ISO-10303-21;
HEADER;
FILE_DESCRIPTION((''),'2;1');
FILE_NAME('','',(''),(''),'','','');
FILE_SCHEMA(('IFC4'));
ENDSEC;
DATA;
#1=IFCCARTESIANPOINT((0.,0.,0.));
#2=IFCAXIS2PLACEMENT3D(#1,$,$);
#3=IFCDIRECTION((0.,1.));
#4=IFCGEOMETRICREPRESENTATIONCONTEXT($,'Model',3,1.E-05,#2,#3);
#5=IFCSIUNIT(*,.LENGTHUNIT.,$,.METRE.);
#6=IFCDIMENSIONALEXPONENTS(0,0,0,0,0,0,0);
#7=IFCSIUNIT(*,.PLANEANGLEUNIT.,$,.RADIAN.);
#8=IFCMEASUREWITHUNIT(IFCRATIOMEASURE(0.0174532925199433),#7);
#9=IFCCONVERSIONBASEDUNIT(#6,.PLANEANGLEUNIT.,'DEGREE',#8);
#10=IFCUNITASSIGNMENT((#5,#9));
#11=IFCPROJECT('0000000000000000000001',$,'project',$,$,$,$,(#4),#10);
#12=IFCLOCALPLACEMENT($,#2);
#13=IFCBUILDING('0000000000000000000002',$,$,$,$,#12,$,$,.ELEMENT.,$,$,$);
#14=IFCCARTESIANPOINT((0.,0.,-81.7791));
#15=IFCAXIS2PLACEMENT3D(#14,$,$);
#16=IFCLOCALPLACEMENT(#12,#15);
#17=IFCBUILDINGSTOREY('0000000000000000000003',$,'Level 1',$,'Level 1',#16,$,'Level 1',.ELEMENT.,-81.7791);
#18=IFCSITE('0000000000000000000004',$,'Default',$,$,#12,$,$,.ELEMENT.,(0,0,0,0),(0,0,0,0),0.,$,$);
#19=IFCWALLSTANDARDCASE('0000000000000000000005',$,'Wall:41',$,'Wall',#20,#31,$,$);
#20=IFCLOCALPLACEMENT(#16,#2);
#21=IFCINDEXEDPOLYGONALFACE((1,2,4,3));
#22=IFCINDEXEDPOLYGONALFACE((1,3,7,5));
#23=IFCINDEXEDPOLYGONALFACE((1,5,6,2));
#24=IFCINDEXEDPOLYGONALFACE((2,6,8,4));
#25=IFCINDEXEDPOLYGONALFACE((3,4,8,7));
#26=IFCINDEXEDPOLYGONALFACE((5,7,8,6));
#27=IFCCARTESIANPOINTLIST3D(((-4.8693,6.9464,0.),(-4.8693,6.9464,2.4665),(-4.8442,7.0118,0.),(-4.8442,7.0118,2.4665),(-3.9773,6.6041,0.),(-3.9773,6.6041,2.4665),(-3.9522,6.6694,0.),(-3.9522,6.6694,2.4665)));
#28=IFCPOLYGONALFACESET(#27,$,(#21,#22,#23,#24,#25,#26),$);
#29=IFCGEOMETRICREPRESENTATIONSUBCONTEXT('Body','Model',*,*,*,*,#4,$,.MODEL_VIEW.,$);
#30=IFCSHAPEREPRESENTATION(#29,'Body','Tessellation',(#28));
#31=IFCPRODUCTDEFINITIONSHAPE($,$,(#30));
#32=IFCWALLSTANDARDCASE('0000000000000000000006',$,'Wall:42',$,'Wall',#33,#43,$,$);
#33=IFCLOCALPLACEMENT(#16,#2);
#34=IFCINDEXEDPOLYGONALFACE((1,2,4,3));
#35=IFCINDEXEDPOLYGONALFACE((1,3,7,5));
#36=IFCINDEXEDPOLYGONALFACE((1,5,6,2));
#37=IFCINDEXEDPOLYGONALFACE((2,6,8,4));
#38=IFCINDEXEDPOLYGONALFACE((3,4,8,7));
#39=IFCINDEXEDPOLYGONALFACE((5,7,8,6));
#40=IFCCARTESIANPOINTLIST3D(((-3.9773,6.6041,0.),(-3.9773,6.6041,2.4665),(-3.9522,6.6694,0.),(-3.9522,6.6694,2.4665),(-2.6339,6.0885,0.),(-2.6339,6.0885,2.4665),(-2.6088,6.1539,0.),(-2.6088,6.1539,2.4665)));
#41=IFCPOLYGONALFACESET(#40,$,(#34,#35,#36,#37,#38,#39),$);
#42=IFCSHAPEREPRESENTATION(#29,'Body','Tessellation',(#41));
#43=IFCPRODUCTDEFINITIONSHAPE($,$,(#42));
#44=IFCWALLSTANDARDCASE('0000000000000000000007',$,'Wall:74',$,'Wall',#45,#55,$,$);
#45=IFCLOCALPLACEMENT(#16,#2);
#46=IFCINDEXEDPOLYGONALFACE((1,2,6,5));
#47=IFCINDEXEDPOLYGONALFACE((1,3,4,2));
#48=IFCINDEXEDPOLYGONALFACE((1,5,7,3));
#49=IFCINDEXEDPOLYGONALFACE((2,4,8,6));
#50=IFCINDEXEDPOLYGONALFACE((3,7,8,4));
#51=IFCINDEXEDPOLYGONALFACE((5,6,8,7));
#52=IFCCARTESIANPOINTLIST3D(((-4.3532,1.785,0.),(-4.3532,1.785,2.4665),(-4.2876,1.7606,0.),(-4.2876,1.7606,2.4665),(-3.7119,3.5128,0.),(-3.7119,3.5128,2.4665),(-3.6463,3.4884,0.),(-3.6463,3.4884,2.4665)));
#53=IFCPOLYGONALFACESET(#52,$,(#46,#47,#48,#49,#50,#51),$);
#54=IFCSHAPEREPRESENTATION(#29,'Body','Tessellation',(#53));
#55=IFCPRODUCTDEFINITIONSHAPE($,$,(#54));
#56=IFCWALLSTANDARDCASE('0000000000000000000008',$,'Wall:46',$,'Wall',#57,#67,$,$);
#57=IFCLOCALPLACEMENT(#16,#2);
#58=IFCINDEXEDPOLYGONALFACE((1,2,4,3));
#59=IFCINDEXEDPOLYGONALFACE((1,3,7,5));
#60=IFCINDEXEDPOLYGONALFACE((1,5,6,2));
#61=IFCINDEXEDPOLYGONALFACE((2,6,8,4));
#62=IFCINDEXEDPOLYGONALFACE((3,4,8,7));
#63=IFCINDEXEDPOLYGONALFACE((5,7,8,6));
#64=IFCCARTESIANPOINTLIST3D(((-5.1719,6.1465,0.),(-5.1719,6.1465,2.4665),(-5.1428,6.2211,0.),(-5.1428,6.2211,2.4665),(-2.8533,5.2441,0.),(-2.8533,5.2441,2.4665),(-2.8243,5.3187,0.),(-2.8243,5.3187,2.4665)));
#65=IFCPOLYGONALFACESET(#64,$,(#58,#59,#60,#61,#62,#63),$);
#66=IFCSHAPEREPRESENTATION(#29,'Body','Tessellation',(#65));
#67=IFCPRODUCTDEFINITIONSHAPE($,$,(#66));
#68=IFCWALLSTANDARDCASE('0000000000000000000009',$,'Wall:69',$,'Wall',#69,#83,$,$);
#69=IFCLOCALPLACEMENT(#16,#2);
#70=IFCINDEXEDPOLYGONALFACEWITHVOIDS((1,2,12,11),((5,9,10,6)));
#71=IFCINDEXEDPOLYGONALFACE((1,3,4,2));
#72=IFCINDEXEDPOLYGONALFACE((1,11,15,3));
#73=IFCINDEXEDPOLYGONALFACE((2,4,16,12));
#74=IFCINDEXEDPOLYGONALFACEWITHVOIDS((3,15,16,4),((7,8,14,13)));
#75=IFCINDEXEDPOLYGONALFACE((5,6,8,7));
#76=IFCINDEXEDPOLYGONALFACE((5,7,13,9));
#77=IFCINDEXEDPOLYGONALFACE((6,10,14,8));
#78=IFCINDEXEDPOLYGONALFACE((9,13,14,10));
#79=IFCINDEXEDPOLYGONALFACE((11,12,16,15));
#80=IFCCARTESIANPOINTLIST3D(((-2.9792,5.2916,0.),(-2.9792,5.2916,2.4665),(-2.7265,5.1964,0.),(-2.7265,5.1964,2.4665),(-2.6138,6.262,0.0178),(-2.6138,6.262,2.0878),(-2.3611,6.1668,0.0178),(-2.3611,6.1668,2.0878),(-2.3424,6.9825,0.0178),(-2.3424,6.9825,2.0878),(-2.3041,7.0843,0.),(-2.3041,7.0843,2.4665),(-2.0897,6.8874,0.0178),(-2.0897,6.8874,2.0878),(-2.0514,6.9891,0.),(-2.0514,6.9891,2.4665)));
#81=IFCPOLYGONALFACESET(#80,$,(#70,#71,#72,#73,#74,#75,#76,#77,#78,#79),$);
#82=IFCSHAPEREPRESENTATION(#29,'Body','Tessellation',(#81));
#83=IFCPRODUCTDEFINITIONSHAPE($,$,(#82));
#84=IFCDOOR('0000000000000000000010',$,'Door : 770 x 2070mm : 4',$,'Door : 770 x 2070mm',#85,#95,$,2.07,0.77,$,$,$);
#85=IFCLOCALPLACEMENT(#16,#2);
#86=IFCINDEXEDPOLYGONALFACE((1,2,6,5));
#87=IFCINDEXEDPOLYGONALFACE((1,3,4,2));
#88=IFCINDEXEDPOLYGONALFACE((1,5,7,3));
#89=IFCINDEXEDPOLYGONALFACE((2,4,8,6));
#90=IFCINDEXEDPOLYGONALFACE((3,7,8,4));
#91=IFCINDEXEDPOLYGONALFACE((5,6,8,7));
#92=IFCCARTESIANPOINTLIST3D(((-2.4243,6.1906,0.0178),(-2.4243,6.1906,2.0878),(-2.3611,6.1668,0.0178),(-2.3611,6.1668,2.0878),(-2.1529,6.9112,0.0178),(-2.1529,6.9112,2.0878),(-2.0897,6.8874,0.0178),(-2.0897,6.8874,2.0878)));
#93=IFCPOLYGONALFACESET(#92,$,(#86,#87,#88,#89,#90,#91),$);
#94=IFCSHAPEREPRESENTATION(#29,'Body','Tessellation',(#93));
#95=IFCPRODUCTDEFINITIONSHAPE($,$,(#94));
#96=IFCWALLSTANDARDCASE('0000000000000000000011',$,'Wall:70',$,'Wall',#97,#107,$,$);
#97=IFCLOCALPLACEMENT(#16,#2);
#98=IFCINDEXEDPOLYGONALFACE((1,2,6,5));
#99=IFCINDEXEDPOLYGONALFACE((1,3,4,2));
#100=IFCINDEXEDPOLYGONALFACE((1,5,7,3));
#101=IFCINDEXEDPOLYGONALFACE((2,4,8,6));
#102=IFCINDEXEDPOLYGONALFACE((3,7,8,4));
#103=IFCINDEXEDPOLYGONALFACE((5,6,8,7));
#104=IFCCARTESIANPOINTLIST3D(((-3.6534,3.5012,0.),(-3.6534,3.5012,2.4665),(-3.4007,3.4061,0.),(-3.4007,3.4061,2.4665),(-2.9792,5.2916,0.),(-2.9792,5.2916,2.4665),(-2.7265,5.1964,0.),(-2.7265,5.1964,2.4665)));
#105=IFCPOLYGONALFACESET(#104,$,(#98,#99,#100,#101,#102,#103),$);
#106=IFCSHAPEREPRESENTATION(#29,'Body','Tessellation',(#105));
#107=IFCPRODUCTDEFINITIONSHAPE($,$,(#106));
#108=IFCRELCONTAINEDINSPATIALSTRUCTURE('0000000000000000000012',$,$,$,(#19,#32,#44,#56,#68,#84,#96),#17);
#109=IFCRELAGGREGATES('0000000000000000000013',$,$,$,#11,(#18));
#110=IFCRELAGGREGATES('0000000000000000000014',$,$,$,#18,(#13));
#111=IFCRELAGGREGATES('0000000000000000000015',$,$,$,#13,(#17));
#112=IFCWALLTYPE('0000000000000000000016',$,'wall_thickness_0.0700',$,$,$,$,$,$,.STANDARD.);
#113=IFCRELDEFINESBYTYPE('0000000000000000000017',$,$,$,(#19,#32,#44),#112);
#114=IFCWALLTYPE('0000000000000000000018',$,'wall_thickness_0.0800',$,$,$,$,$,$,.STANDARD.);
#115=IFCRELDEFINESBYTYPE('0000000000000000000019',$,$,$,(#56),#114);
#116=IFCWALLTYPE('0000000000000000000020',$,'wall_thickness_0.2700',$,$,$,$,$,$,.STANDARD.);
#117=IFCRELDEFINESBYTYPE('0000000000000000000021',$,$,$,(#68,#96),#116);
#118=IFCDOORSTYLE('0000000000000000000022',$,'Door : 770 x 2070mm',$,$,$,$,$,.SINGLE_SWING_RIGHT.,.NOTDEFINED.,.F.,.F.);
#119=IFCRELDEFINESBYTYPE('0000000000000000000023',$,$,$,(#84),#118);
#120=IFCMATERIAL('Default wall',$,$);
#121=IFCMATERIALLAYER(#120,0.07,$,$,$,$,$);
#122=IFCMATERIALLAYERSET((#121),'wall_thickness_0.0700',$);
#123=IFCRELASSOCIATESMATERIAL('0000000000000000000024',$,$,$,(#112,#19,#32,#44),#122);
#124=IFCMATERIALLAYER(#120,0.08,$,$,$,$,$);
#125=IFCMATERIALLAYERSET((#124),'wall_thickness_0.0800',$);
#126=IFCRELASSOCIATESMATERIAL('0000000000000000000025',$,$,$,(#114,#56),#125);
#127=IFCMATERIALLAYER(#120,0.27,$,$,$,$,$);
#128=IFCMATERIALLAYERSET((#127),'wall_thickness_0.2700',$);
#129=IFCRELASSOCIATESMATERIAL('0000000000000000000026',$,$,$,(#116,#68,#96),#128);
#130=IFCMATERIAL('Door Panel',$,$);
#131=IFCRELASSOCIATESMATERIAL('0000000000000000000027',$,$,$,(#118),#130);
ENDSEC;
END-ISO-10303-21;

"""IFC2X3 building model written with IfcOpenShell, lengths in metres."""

from ifc_helpers import new_model, entity, si_unit, converted_unit, direction, frame, frame_2d, origin, origin_2d_with_axis, place, context, subcontext, project, spatial, polyline, rectangle, outline, extrude, source, transform, mapped, material, layer, layer_set, layer_usage, type_object, type_shapes, element, fill, save


model = new_model("IFC2X3")

# Units and contexts
model_context = context("Model", 3, precision=1e-05, world=origin(), true_north=direction((0.0, 1.0)))
body_context = subcontext(model_context, "Body", "Model", "MODEL_VIEW")
ifc_project = project(units=[si_unit("LENGTHUNIT", "METRE"), converted_unit("PLANEANGLEUNIT", "DEGREE", entity("IfcRatioMeasure", 0.0174532925199433), si_unit("PLANEANGLEUNIT", "RADIAN"), dimensions=[0, 0, 0, 0, 0, 0, 0])], contexts=[model_context])

# Site, building, storey
placement_1 = place(None, origin())
site = spatial("IfcSite", under=ifc_project, at=placement_1, Name="Default", CompositionType="ELEMENT", RefLatitude=(0, 0, 0, 0), RefLongitude=(0, 0, 0, 0), RefElevation=0.0)
building = spatial("IfcBuilding", under=site, at=placement_1, CompositionType="ELEMENT")
storey_placement = place(placement_1, frame((0.0, 0.0, -81.7791)))
storey = spatial("IfcBuildingStorey", under=building, at=storey_placement, Name="Level 1", ObjectType="Level 1", LongName="Level 1", CompositionType="ELEMENT", Elevation=-81.7791)

# Shared definitions
ifc_material_1 = material(Name="Default wall")

# Shared definitions
ifc_material_2 = material(Name="Door Panel")

# Walls
ifc_layer_1 = layer(ifc_material_1, 0.07)
ifc_layer_set_1 = layer_set([ifc_layer_1], Name="wall_thickness_0.0700")
ifc_layer_usage_1 = layer_usage(ifc_layer_set_1, "AXIS2", "POSITIVE", -0.035)
wall_type_1 = type_object("IfcWallType", Name="wall_thickness_0.0700", PredefinedType="STANDARD", material=ifc_layer_set_1)
wall_1_placement = place(storey_placement, frame((-4.8567, 6.9791, 0.0), z_axis=(0.0, 0.0, 1.0), x_axis=(0.933604, -0.358305, 0.0)))
element("IfcWallStandardCase", 1, at=wall_1_placement, inside=storey, type_object=wall_type_1, material=ifc_layer_usage_1, Name="Wall:41", ObjectType="Wall", context=body_context, shape_type="SweptSolid", body=[
    extrude(outline(polyline([(0.9554, -0.035), (0.9554, 0.035), (0.0, 0.035), (0.0, -0.035), (0.9554, -0.035)])), origin(), (0.0, 0.0, 1.0), 2.4665),
])
wall_2_placement = place(storey_placement, frame((-3.9647, 6.6368, 0.0), z_axis=(0.0, 0.0, 1.0), x_axis=(0.933604, -0.358305, 0.0)))
element("IfcWallStandardCase", 2, at=wall_2_placement, inside=storey, type_object=wall_type_1, material=ifc_layer_usage_1, Name="Wall:42", ObjectType="Wall", context=body_context, shape_type="SweptSolid", body=[
    extrude(outline(polyline([(1.4389, -0.035), (1.4389, 0.035), (0.0, 0.035), (0.0, -0.035), (1.4389, -0.035)])), origin(), (0.0, 0.0, 1.0), 2.4665),
])
wall_3_placement = place(storey_placement, frame((-3.6791, 3.5006, 0.0), z_axis=(0.0, 0.0, 1.0), x_axis=(-0.347981, -0.937502, 0.0)))
element("IfcWallStandardCase", 3, at=wall_3_placement, inside=storey, type_object=wall_type_1, material=ifc_layer_usage_1, Name="Wall:74", ObjectType="Wall", context=body_context, shape_type="SweptSolid", body=[
    extrude(outline(polyline([(1.843, -0.035), (1.843, 0.035), (0.0, 0.035), (0.0, -0.035), (1.843, -0.035)])), origin(), (0.0, 0.0, 1.0), 2.4665),
])
ifc_layer_2 = layer(ifc_material_1, 0.08)
ifc_layer_set_2 = layer_set([ifc_layer_2], Name="wall_thickness_0.0800")
ifc_layer_usage_2 = layer_usage(ifc_layer_set_2, "AXIS2", "POSITIVE", -0.04)
wall_type_2 = type_object("IfcWallType", Name="wall_thickness_0.0800", PredefinedType="STANDARD", material=ifc_layer_set_2)
wall_4_placement = place(storey_placement, frame((-5.1573, 6.1838, 0.0), z_axis=(0.0, 0.0, 1.0), x_axis=(0.931903, -0.362708, 0.0)))
element("IfcWallStandardCase", 4, at=wall_4_placement, inside=storey, type_object=wall_type_2, material=ifc_layer_usage_2, Name="Wall:46", ObjectType="Wall", context=body_context, shape_type="SweptSolid", body=[
    extrude(outline(polyline([(2.488, -0.04), (2.488, 0.04), (0.0, 0.04), (0.0, -0.04), (2.488, -0.04)])), origin(), (0.0, 0.0, 1.0), 2.4665),
])

# Wall, opening, door
ifc_layer_3 = layer(ifc_material_1, 0.27)
ifc_layer_set_3 = layer_set([ifc_layer_3], Name="wall_thickness_0.2700")
ifc_layer_usage_3 = layer_usage(ifc_layer_set_3, "AXIS2", "POSITIVE", -0.135)
wall_type_3 = type_object("IfcWallType", Name="wall_thickness_0.2700", PredefinedType="STANDARD", material=ifc_layer_set_3)
wall_5_placement = place(storey_placement, frame((-2.1778, 7.0367, 0.0), z_axis=(0.0, 0.0, 1.0), x_axis=(-0.352427, -0.935839, 0.0)))
wall_5 = element("IfcWallStandardCase", 5, at=wall_5_placement, inside=storey, type_object=wall_type_3, material=ifc_layer_usage_3, Name="Wall:69", ObjectType="Wall", context=body_context, shape_type="SweptSolid", body=[
    extrude(outline(polyline([(1.9156, -0.135), (1.9156, 0.135), (0.0, 0.135), (0.0, -0.135), (1.9156, -0.135)])), origin(), (0.0, 0.0, 1.0), 2.4665),
])
opening_1_placement = place(wall_5_placement, frame((0.1087, -0.135, 0.0178)))
opening_1 = element("IfcOpeningElement", 6, at=opening_1_placement, cuts=wall_5, ObjectType="Opening", context=body_context, shape_type="SweptSolid", body=[
    extrude(rectangle(XDim=0.77, YDim=2.07, at=frame_2d((1.035, 0.385), x_axis=(0.0, 1.0))), frame((0.0, 0.0, 0.0), z_axis=(0.0, 1.0, 0.0), x_axis=(0.0, 0.0, 1.0)), (0.0, 0.0, 1.0), 0.27),
])
door_style_1 = type_object("IfcDoorStyle", Name="Door : 770 x 2070mm", ConstructionType="NOTDEFINED", OperationType="SINGLE_SWING_RIGHT", ParameterTakesPrecedence=False, Sizeable=False, material=ifc_material_2)
shared_shape_1 = source(origin(), body_context, "Body", "SweptSolid", [
    extrude(rectangle(XDim=0.0675, YDim=0.77, at=origin_2d_with_axis()), frame((0.385, 0.2363, 0.0), z_axis=(0.0, 0.0, 1.0), x_axis=(0.0, 1.0, 0.0)), (0.0, 0.0, 1.0), 2.07),
])
type_shapes(door_style_1, [shared_shape_1])
door_1_placement = place(opening_1_placement, origin())
door_1 = element("IfcDoor", 7, at=door_1_placement, inside=storey, type_object=door_style_1, Name="Door : 770 x 2070mm : 4", ObjectType="Door : 770 x 2070mm", OverallHeight=2.07, OverallWidth=0.77, context=body_context, shape_type="MappedRepresentation", body=[
    mapped(shared_shape_1, transform((0.0, 0.0, 0.0), scale=1.0)),
])
fill(opening_1, door_1)

# Wall
wall_6_placement = place(storey_placement, frame((-2.8529, 5.244, 0.0), z_axis=(0.0, 0.0, 1.0), x_axis=(-0.352427, -0.935839, 0.0)))
element("IfcWallStandardCase", 8, at=wall_6_placement, inside=storey, type_object=wall_type_3, material=ifc_layer_usage_3, Name="Wall:70", ObjectType="Wall", context=body_context, shape_type="SweptSolid", body=[
    extrude(outline(polyline([(1.913, -0.135), (1.913, 0.135), (0.0, 0.135), (0.0, -0.135), (1.913, -0.135)])), origin(), (0.0, 0.0, 1.0), 2.4665),
])

save(model, "model.ifc")
